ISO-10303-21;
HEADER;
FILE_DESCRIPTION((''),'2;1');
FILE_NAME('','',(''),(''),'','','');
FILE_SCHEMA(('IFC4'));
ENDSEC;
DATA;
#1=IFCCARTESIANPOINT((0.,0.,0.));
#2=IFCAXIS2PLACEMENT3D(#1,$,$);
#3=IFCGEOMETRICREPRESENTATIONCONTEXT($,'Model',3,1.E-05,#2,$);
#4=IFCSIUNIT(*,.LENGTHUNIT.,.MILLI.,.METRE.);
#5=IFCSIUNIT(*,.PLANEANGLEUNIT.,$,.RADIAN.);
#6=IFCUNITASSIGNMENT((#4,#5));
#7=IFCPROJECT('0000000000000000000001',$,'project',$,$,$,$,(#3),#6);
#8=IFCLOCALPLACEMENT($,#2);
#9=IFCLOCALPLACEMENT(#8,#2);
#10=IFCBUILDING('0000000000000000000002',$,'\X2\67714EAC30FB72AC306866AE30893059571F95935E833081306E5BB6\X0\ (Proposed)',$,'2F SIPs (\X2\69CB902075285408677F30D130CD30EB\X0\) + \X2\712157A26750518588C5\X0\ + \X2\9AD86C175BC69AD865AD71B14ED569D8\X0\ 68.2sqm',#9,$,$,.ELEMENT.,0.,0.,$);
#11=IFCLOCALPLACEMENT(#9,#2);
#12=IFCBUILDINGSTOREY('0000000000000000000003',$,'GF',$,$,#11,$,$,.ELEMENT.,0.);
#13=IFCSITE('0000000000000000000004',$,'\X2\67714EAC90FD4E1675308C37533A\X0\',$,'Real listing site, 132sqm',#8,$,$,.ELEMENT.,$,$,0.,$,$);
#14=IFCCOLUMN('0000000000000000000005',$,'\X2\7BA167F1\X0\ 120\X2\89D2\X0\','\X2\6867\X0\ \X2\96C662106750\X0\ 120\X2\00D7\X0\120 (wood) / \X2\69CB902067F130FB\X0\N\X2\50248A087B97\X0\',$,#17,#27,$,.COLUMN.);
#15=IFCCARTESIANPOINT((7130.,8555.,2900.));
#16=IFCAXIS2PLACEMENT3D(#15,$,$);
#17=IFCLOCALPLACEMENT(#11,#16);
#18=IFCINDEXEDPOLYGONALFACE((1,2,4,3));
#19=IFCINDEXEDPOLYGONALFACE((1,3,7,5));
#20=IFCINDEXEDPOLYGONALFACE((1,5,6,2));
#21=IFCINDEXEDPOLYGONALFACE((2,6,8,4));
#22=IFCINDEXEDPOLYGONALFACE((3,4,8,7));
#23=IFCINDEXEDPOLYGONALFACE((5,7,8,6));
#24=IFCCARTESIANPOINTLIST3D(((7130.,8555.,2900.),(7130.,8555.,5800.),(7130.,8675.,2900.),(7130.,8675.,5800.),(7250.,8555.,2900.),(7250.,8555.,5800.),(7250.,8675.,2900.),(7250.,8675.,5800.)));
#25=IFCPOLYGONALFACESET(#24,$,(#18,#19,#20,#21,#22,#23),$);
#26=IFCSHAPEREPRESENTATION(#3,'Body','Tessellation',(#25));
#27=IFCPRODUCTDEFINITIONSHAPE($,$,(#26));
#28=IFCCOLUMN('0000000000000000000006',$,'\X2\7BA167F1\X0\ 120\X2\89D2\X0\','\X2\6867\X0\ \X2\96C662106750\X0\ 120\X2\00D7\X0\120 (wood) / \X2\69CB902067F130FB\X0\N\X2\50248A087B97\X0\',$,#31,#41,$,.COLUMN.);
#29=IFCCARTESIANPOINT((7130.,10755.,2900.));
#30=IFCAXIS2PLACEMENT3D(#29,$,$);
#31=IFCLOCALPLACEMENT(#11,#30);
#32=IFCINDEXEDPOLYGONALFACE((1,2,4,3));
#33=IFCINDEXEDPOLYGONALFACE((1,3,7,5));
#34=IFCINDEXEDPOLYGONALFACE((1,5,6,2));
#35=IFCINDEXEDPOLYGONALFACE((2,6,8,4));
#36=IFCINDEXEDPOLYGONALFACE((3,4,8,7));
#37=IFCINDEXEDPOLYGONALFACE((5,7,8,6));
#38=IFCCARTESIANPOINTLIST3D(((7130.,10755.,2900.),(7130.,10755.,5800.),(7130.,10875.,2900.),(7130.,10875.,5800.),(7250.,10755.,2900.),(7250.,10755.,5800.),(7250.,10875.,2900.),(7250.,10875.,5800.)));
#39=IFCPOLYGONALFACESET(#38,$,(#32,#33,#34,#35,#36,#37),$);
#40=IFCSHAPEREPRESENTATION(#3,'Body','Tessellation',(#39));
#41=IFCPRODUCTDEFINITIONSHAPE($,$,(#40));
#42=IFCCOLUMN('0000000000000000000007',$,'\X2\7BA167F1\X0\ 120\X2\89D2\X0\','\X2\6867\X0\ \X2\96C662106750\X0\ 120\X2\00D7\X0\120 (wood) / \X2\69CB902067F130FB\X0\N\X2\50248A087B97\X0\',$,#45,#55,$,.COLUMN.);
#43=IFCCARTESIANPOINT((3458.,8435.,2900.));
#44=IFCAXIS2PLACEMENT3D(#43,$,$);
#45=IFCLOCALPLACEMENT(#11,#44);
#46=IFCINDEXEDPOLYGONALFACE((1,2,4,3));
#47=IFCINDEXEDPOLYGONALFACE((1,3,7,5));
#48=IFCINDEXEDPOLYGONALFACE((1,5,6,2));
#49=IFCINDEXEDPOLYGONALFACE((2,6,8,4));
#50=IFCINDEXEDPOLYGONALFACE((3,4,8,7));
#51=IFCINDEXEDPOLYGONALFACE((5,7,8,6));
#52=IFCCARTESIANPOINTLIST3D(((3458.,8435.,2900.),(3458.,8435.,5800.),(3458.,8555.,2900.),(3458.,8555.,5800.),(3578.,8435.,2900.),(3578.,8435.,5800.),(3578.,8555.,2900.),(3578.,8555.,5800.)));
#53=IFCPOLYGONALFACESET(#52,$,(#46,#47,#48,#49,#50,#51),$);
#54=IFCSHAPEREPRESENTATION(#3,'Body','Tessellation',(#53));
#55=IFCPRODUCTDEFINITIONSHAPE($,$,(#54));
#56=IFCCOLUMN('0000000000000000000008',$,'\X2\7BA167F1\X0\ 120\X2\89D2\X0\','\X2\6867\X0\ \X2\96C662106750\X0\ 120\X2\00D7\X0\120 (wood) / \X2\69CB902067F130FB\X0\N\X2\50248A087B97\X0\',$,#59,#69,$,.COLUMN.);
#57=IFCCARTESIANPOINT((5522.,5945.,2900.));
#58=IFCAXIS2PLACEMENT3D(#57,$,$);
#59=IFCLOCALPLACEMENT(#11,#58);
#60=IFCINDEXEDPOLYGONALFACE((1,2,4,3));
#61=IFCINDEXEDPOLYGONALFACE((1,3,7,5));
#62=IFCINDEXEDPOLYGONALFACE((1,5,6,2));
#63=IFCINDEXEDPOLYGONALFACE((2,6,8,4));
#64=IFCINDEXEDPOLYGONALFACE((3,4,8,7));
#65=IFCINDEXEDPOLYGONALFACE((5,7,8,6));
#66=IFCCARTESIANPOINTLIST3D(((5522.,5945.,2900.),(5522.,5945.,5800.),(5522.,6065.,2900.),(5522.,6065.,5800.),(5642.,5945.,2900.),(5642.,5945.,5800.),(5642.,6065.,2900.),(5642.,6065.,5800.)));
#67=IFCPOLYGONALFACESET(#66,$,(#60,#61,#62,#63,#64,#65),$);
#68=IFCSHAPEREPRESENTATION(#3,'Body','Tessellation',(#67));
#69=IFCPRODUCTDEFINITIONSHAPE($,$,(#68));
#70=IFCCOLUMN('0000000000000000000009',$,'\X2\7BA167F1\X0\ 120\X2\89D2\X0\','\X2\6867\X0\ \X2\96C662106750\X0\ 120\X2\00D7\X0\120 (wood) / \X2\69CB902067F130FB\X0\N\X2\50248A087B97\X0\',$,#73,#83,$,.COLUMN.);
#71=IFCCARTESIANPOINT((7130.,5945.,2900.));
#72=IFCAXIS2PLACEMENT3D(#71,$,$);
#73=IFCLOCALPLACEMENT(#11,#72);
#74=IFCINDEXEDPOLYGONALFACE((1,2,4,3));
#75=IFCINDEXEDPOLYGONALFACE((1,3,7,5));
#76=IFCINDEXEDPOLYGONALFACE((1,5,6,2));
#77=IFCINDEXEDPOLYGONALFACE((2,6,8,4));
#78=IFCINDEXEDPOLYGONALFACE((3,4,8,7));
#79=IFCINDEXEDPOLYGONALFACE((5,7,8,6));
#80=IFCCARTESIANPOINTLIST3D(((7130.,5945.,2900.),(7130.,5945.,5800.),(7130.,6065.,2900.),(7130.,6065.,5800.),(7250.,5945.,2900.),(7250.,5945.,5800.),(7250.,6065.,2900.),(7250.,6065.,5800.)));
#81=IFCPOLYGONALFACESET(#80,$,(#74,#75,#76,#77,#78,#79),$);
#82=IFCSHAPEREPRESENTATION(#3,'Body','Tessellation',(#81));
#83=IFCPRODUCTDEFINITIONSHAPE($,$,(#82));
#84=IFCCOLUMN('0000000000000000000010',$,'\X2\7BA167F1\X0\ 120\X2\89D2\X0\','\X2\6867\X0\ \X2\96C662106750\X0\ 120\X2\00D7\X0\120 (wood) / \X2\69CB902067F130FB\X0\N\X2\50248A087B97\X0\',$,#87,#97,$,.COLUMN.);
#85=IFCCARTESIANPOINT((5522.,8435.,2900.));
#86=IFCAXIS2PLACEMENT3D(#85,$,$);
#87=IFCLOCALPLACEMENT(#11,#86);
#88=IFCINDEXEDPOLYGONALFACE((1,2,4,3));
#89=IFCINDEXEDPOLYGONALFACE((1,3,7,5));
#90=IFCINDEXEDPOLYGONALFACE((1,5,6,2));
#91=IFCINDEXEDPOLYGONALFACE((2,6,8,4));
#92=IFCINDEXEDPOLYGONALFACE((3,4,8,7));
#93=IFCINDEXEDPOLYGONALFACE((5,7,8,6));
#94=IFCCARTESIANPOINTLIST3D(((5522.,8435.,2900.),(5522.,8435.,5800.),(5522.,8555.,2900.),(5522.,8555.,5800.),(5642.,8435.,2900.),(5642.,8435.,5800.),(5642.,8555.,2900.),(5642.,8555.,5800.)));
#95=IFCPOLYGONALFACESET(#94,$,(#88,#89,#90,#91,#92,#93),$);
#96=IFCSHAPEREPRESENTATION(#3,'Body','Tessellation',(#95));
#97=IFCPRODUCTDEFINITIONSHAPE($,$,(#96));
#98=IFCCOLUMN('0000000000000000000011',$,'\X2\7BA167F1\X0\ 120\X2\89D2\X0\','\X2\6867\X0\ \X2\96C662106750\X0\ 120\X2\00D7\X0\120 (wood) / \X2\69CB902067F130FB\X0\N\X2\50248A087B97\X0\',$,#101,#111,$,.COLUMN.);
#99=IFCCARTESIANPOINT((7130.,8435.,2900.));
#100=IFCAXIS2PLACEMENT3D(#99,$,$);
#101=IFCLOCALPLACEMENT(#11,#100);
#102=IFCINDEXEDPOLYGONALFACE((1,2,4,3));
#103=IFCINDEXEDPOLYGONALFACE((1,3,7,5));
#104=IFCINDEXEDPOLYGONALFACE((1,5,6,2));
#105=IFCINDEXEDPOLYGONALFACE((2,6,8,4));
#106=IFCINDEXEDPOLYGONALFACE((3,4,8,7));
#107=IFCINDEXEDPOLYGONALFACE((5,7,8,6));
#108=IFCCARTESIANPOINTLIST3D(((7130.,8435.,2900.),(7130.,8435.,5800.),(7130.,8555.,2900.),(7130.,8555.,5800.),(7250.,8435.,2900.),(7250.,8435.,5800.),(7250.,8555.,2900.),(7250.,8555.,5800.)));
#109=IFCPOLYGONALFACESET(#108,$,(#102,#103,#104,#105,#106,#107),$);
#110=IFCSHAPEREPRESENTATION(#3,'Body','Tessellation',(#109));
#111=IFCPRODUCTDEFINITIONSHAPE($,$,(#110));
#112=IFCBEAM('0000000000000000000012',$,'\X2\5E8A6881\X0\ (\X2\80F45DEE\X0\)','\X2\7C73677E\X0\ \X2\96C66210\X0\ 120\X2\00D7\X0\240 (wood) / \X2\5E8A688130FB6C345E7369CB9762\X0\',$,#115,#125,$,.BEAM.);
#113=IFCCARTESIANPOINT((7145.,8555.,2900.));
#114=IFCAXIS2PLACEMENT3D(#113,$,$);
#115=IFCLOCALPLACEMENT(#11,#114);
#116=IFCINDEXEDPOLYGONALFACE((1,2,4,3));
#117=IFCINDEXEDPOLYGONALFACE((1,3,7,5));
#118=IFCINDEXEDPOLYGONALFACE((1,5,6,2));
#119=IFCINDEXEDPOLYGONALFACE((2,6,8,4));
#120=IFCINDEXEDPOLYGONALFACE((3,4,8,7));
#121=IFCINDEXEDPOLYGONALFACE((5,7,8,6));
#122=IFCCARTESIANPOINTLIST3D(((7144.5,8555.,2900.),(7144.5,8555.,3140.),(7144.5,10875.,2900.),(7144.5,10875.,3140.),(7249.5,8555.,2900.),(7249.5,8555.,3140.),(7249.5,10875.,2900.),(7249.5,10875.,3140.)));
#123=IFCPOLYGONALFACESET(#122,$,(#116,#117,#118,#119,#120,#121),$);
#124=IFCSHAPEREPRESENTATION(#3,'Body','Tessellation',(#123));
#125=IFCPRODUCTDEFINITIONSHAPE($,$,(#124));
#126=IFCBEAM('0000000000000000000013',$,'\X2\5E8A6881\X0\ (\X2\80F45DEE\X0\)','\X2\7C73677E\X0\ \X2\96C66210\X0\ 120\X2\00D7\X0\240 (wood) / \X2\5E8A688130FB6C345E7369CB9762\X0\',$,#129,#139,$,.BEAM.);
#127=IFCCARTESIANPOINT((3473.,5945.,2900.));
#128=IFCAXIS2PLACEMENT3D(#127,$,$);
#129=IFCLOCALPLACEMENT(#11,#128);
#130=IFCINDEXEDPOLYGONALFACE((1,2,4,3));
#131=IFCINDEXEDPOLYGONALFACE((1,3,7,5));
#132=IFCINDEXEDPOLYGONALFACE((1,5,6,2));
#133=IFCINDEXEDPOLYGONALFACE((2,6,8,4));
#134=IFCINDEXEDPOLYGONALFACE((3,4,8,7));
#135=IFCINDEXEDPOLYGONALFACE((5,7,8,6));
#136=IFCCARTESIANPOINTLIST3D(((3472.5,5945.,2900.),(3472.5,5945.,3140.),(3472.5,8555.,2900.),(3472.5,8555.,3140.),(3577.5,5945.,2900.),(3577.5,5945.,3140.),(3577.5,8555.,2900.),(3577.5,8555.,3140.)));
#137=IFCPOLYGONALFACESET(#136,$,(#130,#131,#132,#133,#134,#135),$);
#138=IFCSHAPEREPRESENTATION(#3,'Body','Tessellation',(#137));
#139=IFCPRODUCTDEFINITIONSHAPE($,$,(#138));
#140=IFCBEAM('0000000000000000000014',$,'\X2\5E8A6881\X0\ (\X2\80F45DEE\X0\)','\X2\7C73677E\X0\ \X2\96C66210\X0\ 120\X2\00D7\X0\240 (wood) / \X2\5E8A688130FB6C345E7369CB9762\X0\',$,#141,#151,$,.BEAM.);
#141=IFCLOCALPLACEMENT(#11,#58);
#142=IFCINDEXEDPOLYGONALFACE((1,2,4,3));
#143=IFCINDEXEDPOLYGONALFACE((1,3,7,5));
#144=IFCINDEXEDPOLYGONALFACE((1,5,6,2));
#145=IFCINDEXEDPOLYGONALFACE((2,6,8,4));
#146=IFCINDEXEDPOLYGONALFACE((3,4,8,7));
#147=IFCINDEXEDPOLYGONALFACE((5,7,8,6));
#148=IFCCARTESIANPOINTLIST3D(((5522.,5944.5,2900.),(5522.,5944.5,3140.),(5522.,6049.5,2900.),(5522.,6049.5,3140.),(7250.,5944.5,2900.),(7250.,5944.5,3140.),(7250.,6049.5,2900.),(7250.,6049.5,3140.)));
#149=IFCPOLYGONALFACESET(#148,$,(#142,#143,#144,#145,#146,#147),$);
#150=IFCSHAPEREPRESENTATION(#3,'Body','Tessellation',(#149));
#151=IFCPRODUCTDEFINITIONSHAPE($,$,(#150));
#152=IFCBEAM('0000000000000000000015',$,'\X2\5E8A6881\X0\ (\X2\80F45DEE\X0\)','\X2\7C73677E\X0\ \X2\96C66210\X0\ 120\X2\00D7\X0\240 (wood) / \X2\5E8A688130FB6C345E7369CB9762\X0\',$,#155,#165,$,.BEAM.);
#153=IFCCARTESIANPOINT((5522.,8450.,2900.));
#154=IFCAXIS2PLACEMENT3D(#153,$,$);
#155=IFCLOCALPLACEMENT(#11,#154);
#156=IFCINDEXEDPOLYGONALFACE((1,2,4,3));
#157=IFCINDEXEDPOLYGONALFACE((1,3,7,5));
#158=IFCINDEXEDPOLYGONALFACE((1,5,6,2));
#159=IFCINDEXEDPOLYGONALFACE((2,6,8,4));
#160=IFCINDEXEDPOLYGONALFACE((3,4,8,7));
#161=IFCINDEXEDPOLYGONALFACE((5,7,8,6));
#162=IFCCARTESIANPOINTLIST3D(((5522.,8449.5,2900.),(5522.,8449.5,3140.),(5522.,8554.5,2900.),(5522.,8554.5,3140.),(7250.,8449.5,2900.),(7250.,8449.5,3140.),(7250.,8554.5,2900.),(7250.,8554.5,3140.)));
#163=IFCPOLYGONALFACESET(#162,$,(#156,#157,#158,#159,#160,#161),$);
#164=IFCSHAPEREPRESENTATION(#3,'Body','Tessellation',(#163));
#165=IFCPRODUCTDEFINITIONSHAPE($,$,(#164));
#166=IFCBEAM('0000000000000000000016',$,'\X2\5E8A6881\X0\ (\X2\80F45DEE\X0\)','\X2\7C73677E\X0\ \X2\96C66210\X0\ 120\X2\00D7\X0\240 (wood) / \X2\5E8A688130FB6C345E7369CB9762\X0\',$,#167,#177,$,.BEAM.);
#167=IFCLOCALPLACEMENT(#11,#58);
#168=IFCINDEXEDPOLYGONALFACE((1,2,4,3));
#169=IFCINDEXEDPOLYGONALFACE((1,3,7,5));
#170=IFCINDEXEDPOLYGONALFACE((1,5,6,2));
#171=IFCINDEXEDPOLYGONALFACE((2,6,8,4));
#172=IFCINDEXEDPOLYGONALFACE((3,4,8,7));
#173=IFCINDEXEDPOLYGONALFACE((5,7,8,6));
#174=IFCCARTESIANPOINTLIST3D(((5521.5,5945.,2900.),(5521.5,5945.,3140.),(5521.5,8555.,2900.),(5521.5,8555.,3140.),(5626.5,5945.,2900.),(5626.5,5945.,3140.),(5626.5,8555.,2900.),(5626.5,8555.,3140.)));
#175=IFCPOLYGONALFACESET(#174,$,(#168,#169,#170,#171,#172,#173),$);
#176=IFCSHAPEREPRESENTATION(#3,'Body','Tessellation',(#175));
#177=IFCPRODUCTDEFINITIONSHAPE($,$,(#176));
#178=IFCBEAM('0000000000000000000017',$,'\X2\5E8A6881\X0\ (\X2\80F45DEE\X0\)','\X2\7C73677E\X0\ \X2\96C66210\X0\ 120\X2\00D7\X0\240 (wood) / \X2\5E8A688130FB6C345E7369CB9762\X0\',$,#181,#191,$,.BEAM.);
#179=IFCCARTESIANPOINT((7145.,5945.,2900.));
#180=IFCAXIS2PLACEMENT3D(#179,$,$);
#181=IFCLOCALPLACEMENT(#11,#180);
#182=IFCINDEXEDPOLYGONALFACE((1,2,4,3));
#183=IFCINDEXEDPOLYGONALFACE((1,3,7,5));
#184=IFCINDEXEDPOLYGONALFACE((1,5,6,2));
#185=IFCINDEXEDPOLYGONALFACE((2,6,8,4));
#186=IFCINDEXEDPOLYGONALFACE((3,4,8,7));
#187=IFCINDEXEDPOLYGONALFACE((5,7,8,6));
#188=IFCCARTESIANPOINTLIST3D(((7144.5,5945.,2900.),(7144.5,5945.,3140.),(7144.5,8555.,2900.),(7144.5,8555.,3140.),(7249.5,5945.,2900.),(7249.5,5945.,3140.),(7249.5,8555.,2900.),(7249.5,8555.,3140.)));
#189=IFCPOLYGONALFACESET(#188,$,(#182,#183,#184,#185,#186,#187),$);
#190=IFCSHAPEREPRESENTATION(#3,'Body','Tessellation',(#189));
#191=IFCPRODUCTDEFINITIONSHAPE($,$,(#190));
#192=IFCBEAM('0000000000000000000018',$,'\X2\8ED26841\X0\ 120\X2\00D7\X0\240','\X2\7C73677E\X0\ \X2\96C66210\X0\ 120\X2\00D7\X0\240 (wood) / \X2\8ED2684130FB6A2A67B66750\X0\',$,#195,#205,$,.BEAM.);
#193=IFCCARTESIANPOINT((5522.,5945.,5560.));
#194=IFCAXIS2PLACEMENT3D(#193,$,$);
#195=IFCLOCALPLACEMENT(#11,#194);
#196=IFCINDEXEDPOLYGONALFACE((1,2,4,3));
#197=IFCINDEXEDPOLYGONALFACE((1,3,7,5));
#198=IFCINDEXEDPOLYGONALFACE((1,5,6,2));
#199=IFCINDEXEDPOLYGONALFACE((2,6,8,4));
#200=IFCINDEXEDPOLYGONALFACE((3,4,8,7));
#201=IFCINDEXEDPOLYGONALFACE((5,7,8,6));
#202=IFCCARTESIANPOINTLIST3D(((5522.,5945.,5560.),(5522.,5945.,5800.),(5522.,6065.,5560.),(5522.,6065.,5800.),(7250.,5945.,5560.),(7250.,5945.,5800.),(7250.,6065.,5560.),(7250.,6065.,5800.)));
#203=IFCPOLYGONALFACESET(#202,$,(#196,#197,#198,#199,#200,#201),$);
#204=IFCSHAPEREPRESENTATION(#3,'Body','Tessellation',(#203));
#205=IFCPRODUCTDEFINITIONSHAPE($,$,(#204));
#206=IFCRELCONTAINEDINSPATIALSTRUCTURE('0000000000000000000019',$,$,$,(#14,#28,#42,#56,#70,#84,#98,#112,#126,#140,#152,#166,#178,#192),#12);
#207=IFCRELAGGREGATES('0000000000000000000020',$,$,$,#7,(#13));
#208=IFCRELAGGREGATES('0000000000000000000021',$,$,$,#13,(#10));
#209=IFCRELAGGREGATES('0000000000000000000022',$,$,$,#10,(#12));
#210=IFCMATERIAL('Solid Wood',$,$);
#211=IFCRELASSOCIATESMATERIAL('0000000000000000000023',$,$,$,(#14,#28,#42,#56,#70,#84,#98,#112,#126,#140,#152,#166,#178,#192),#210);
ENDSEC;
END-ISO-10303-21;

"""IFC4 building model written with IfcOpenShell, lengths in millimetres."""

from ifc_helpers import new_model, si_unit, frame, frame_2d, origin, place, context, project, spatial, rectangle, extrude, material, element, save


model = new_model("IFC4")

# Units and contexts
model_context = context("Model", 3, precision=1e-05, world=origin())
ifc_project = project(units=[si_unit("LENGTHUNIT", "METRE", prefix="MILLI"), si_unit("PLANEANGLEUNIT", "RADIAN")], contexts=[model_context])

# Site, building, storey
site_placement = place(None, origin())
site = spatial("IfcSite", under=ifc_project, at=site_placement, Name="東京都世田谷区", ObjectType="Real listing site, 132sqm", CompositionType="ELEMENT", RefElevation=0.0)
building_placement = place(site_placement, origin())
building = spatial("IfcBuilding", under=site, at=building_placement, Name="東京・犬と暮らす土間広めの家 (Proposed)", ObjectType="2F SIPs (構造用合板パネル) + 無垢材内装 + 高気密高断熱仕様 68.2sqm", CompositionType="ELEMENT", ElevationOfRefHeight=0.0, ElevationOfTerrain=0.0)
storey_placement = place(building_placement, origin())
storey = spatial("IfcBuildingStorey", under=building, at=storey_placement, Name="GF", CompositionType="ELEMENT", Elevation=0.0)

# Columns
ifc_material_1 = material(Name="Solid Wood")
column_1_placement = place(storey_placement, frame((7130.0, 8555.0, 2900.0)))
element("IfcColumn", 1, at=column_1_placement, inside=storey, material=ifc_material_1, Name="管柱 120角", Description="桧 集成材 120×120 (wood) / 構造柱・N値計算", PredefinedType="COLUMN", context=model_context, shape_type="SweptSolid", body=[
    extrude(rectangle(XDim=120.0, YDim=120.0, at=frame_2d((60.0, 60.0))), frame((7130.0, 8555.0, 2900.0)), (0.0, 0.0, 1.0), 2900.0),
])
column_2_placement = place(storey_placement, frame((7130.0, 10755.0, 2900.0)))
element("IfcColumn", 2, at=column_2_placement, inside=storey, material=ifc_material_1, Name="管柱 120角", Description="桧 集成材 120×120 (wood) / 構造柱・N値計算", PredefinedType="COLUMN", context=model_context, shape_type="SweptSolid", body=[
    extrude(rectangle(XDim=120.0, YDim=120.0, at=frame_2d((60.0, 60.0))), frame((7130.0, 10755.0, 2900.0)), (0.0, 0.0, 1.0), 2900.0),
])
column_3_placement = place(storey_placement, frame((3458.0, 8435.0, 2900.0)))
element("IfcColumn", 3, at=column_3_placement, inside=storey, material=ifc_material_1, Name="管柱 120角", Description="桧 集成材 120×120 (wood) / 構造柱・N値計算", PredefinedType="COLUMN", context=model_context, shape_type="SweptSolid", body=[
    extrude(rectangle(XDim=120.0, YDim=120.0, at=frame_2d((60.0, 60.0))), frame((3458.0, 8435.0, 2900.0)), (0.0, 0.0, 1.0), 2900.0),
])
column_4_placement = place(storey_placement, frame((5522.0, 5945.0, 2900.0)))
element("IfcColumn", 4, at=column_4_placement, inside=storey, material=ifc_material_1, Name="管柱 120角", Description="桧 集成材 120×120 (wood) / 構造柱・N値計算", PredefinedType="COLUMN", context=model_context, shape_type="SweptSolid", body=[
    extrude(rectangle(XDim=120.0, YDim=120.0, at=frame_2d((60.0, 60.0))), frame((5522.0, 5945.0, 2900.0)), (0.0, 0.0, 1.0), 2900.0),
])
column_5_placement = place(storey_placement, frame((7130.0, 5945.0, 2900.0)))
element("IfcColumn", 5, at=column_5_placement, inside=storey, material=ifc_material_1, Name="管柱 120角", Description="桧 集成材 120×120 (wood) / 構造柱・N値計算", PredefinedType="COLUMN", context=model_context, shape_type="SweptSolid", body=[
    extrude(rectangle(XDim=120.0, YDim=120.0, at=frame_2d((60.0, 60.0))), frame((7130.0, 5945.0, 2900.0)), (0.0, 0.0, 1.0), 2900.0),
])
column_6_placement = place(storey_placement, frame((5522.0, 8435.0, 2900.0)))
element("IfcColumn", 6, at=column_6_placement, inside=storey, material=ifc_material_1, Name="管柱 120角", Description="桧 集成材 120×120 (wood) / 構造柱・N値計算", PredefinedType="COLUMN", context=model_context, shape_type="SweptSolid", body=[
    extrude(rectangle(XDim=120.0, YDim=120.0, at=frame_2d((60.0, 60.0))), frame((5522.0, 8435.0, 2900.0)), (0.0, 0.0, 1.0), 2900.0),
])
column_7_placement = place(storey_placement, frame((7130.0, 8435.0, 2900.0)))
element("IfcColumn", 7, at=column_7_placement, inside=storey, material=ifc_material_1, Name="管柱 120角", Description="桧 集成材 120×120 (wood) / 構造柱・N値計算", PredefinedType="COLUMN", context=model_context, shape_type="SweptSolid", body=[
    extrude(rectangle(XDim=120.0, YDim=120.0, at=frame_2d((60.0, 60.0))), frame((7130.0, 8435.0, 2900.0)), (0.0, 0.0, 1.0), 2900.0),
])

# Beams
beam_1_placement = place(storey_placement, frame((7145.0, 8555.0, 2900.0)))
element("IfcBeam", 8, at=beam_1_placement, inside=storey, material=ifc_material_1, Name="床梁 (胴差)", Description="米松 集成 120×240 (wood) / 床梁・水平構面", PredefinedType="BEAM", context=model_context, shape_type="SweptSolid", body=[
    extrude(rectangle(XDim=105.0, YDim=2320.0, at=frame_2d((52.0, 1160.0))), frame((7145.0, 8555.0, 2900.0)), (0.0, 0.0, 1.0), 240.0),
])
beam_2_placement = place(storey_placement, frame((3473.0, 5945.0, 2900.0)))
element("IfcBeam", 9, at=beam_2_placement, inside=storey, material=ifc_material_1, Name="床梁 (胴差)", Description="米松 集成 120×240 (wood) / 床梁・水平構面", PredefinedType="BEAM", context=model_context, shape_type="SweptSolid", body=[
    extrude(rectangle(XDim=105.0, YDim=2610.0, at=frame_2d((52.0, 1305.0))), frame((3473.0, 5945.0, 2900.0)), (0.0, 0.0, 1.0), 240.0),
])
beam_3_placement = place(storey_placement, frame((5522.0, 5945.0, 2900.0)))
element("IfcBeam", 10, at=beam_3_placement, inside=storey, material=ifc_material_1, Name="床梁 (胴差)", Description="米松 集成 120×240 (wood) / 床梁・水平構面", PredefinedType="BEAM", context=model_context, shape_type="SweptSolid", body=[
    extrude(rectangle(XDim=1728.0, YDim=105.0, at=frame_2d((864.0, 52.0))), frame((5522.0, 5945.0, 2900.0)), (0.0, 0.0, 1.0), 240.0),
])
beam_4_placement = place(storey_placement, frame((5522.0, 8450.0, 2900.0)))
element("IfcBeam", 11, at=beam_4_placement, inside=storey, material=ifc_material_1, Name="床梁 (胴差)", Description="米松 集成 120×240 (wood) / 床梁・水平構面", PredefinedType="BEAM", context=model_context, shape_type="SweptSolid", body=[
    extrude(rectangle(XDim=1728.0, YDim=105.0, at=frame_2d((864.0, 52.0))), frame((5522.0, 8450.0, 2900.0)), (0.0, 0.0, 1.0), 240.0),
])
beam_5_placement = place(storey_placement, frame((5522.0, 5945.0, 2900.0)))
element("IfcBeam", 12, at=beam_5_placement, inside=storey, material=ifc_material_1, Name="床梁 (胴差)", Description="米松 集成 120×240 (wood) / 床梁・水平構面", PredefinedType="BEAM", context=model_context, shape_type="SweptSolid", body=[
    extrude(rectangle(XDim=105.0, YDim=2610.0, at=frame_2d((52.0, 1305.0))), frame((5522.0, 5945.0, 2900.0)), (0.0, 0.0, 1.0), 240.0),
])
beam_6_placement = place(storey_placement, frame((7145.0, 5945.0, 2900.0)))
element("IfcBeam", 13, at=beam_6_placement, inside=storey, material=ifc_material_1, Name="床梁 (胴差)", Description="米松 集成 120×240 (wood) / 床梁・水平構面", PredefinedType="BEAM", context=model_context, shape_type="SweptSolid", body=[
    extrude(rectangle(XDim=105.0, YDim=2610.0, at=frame_2d((52.0, 1305.0))), frame((7145.0, 5945.0, 2900.0)), (0.0, 0.0, 1.0), 240.0),
])
beam_7_placement = place(storey_placement, frame((5522.0, 5945.0, 5560.0)))
element("IfcBeam", 14, at=beam_7_placement, inside=storey, material=ifc_material_1, Name="軒桁 120×240", Description="米松 集成 120×240 (wood) / 軒桁・横架材", PredefinedType="BEAM", context=model_context, shape_type="SweptSolid", body=[
    extrude(rectangle(XDim=1728.0, YDim=120.0, at=frame_2d((864.0, 60.0))), frame((5522.0, 5945.0, 5560.0)), (0.0, 0.0, 1.0), 240.0),
])

save(model, "model.ifc")
